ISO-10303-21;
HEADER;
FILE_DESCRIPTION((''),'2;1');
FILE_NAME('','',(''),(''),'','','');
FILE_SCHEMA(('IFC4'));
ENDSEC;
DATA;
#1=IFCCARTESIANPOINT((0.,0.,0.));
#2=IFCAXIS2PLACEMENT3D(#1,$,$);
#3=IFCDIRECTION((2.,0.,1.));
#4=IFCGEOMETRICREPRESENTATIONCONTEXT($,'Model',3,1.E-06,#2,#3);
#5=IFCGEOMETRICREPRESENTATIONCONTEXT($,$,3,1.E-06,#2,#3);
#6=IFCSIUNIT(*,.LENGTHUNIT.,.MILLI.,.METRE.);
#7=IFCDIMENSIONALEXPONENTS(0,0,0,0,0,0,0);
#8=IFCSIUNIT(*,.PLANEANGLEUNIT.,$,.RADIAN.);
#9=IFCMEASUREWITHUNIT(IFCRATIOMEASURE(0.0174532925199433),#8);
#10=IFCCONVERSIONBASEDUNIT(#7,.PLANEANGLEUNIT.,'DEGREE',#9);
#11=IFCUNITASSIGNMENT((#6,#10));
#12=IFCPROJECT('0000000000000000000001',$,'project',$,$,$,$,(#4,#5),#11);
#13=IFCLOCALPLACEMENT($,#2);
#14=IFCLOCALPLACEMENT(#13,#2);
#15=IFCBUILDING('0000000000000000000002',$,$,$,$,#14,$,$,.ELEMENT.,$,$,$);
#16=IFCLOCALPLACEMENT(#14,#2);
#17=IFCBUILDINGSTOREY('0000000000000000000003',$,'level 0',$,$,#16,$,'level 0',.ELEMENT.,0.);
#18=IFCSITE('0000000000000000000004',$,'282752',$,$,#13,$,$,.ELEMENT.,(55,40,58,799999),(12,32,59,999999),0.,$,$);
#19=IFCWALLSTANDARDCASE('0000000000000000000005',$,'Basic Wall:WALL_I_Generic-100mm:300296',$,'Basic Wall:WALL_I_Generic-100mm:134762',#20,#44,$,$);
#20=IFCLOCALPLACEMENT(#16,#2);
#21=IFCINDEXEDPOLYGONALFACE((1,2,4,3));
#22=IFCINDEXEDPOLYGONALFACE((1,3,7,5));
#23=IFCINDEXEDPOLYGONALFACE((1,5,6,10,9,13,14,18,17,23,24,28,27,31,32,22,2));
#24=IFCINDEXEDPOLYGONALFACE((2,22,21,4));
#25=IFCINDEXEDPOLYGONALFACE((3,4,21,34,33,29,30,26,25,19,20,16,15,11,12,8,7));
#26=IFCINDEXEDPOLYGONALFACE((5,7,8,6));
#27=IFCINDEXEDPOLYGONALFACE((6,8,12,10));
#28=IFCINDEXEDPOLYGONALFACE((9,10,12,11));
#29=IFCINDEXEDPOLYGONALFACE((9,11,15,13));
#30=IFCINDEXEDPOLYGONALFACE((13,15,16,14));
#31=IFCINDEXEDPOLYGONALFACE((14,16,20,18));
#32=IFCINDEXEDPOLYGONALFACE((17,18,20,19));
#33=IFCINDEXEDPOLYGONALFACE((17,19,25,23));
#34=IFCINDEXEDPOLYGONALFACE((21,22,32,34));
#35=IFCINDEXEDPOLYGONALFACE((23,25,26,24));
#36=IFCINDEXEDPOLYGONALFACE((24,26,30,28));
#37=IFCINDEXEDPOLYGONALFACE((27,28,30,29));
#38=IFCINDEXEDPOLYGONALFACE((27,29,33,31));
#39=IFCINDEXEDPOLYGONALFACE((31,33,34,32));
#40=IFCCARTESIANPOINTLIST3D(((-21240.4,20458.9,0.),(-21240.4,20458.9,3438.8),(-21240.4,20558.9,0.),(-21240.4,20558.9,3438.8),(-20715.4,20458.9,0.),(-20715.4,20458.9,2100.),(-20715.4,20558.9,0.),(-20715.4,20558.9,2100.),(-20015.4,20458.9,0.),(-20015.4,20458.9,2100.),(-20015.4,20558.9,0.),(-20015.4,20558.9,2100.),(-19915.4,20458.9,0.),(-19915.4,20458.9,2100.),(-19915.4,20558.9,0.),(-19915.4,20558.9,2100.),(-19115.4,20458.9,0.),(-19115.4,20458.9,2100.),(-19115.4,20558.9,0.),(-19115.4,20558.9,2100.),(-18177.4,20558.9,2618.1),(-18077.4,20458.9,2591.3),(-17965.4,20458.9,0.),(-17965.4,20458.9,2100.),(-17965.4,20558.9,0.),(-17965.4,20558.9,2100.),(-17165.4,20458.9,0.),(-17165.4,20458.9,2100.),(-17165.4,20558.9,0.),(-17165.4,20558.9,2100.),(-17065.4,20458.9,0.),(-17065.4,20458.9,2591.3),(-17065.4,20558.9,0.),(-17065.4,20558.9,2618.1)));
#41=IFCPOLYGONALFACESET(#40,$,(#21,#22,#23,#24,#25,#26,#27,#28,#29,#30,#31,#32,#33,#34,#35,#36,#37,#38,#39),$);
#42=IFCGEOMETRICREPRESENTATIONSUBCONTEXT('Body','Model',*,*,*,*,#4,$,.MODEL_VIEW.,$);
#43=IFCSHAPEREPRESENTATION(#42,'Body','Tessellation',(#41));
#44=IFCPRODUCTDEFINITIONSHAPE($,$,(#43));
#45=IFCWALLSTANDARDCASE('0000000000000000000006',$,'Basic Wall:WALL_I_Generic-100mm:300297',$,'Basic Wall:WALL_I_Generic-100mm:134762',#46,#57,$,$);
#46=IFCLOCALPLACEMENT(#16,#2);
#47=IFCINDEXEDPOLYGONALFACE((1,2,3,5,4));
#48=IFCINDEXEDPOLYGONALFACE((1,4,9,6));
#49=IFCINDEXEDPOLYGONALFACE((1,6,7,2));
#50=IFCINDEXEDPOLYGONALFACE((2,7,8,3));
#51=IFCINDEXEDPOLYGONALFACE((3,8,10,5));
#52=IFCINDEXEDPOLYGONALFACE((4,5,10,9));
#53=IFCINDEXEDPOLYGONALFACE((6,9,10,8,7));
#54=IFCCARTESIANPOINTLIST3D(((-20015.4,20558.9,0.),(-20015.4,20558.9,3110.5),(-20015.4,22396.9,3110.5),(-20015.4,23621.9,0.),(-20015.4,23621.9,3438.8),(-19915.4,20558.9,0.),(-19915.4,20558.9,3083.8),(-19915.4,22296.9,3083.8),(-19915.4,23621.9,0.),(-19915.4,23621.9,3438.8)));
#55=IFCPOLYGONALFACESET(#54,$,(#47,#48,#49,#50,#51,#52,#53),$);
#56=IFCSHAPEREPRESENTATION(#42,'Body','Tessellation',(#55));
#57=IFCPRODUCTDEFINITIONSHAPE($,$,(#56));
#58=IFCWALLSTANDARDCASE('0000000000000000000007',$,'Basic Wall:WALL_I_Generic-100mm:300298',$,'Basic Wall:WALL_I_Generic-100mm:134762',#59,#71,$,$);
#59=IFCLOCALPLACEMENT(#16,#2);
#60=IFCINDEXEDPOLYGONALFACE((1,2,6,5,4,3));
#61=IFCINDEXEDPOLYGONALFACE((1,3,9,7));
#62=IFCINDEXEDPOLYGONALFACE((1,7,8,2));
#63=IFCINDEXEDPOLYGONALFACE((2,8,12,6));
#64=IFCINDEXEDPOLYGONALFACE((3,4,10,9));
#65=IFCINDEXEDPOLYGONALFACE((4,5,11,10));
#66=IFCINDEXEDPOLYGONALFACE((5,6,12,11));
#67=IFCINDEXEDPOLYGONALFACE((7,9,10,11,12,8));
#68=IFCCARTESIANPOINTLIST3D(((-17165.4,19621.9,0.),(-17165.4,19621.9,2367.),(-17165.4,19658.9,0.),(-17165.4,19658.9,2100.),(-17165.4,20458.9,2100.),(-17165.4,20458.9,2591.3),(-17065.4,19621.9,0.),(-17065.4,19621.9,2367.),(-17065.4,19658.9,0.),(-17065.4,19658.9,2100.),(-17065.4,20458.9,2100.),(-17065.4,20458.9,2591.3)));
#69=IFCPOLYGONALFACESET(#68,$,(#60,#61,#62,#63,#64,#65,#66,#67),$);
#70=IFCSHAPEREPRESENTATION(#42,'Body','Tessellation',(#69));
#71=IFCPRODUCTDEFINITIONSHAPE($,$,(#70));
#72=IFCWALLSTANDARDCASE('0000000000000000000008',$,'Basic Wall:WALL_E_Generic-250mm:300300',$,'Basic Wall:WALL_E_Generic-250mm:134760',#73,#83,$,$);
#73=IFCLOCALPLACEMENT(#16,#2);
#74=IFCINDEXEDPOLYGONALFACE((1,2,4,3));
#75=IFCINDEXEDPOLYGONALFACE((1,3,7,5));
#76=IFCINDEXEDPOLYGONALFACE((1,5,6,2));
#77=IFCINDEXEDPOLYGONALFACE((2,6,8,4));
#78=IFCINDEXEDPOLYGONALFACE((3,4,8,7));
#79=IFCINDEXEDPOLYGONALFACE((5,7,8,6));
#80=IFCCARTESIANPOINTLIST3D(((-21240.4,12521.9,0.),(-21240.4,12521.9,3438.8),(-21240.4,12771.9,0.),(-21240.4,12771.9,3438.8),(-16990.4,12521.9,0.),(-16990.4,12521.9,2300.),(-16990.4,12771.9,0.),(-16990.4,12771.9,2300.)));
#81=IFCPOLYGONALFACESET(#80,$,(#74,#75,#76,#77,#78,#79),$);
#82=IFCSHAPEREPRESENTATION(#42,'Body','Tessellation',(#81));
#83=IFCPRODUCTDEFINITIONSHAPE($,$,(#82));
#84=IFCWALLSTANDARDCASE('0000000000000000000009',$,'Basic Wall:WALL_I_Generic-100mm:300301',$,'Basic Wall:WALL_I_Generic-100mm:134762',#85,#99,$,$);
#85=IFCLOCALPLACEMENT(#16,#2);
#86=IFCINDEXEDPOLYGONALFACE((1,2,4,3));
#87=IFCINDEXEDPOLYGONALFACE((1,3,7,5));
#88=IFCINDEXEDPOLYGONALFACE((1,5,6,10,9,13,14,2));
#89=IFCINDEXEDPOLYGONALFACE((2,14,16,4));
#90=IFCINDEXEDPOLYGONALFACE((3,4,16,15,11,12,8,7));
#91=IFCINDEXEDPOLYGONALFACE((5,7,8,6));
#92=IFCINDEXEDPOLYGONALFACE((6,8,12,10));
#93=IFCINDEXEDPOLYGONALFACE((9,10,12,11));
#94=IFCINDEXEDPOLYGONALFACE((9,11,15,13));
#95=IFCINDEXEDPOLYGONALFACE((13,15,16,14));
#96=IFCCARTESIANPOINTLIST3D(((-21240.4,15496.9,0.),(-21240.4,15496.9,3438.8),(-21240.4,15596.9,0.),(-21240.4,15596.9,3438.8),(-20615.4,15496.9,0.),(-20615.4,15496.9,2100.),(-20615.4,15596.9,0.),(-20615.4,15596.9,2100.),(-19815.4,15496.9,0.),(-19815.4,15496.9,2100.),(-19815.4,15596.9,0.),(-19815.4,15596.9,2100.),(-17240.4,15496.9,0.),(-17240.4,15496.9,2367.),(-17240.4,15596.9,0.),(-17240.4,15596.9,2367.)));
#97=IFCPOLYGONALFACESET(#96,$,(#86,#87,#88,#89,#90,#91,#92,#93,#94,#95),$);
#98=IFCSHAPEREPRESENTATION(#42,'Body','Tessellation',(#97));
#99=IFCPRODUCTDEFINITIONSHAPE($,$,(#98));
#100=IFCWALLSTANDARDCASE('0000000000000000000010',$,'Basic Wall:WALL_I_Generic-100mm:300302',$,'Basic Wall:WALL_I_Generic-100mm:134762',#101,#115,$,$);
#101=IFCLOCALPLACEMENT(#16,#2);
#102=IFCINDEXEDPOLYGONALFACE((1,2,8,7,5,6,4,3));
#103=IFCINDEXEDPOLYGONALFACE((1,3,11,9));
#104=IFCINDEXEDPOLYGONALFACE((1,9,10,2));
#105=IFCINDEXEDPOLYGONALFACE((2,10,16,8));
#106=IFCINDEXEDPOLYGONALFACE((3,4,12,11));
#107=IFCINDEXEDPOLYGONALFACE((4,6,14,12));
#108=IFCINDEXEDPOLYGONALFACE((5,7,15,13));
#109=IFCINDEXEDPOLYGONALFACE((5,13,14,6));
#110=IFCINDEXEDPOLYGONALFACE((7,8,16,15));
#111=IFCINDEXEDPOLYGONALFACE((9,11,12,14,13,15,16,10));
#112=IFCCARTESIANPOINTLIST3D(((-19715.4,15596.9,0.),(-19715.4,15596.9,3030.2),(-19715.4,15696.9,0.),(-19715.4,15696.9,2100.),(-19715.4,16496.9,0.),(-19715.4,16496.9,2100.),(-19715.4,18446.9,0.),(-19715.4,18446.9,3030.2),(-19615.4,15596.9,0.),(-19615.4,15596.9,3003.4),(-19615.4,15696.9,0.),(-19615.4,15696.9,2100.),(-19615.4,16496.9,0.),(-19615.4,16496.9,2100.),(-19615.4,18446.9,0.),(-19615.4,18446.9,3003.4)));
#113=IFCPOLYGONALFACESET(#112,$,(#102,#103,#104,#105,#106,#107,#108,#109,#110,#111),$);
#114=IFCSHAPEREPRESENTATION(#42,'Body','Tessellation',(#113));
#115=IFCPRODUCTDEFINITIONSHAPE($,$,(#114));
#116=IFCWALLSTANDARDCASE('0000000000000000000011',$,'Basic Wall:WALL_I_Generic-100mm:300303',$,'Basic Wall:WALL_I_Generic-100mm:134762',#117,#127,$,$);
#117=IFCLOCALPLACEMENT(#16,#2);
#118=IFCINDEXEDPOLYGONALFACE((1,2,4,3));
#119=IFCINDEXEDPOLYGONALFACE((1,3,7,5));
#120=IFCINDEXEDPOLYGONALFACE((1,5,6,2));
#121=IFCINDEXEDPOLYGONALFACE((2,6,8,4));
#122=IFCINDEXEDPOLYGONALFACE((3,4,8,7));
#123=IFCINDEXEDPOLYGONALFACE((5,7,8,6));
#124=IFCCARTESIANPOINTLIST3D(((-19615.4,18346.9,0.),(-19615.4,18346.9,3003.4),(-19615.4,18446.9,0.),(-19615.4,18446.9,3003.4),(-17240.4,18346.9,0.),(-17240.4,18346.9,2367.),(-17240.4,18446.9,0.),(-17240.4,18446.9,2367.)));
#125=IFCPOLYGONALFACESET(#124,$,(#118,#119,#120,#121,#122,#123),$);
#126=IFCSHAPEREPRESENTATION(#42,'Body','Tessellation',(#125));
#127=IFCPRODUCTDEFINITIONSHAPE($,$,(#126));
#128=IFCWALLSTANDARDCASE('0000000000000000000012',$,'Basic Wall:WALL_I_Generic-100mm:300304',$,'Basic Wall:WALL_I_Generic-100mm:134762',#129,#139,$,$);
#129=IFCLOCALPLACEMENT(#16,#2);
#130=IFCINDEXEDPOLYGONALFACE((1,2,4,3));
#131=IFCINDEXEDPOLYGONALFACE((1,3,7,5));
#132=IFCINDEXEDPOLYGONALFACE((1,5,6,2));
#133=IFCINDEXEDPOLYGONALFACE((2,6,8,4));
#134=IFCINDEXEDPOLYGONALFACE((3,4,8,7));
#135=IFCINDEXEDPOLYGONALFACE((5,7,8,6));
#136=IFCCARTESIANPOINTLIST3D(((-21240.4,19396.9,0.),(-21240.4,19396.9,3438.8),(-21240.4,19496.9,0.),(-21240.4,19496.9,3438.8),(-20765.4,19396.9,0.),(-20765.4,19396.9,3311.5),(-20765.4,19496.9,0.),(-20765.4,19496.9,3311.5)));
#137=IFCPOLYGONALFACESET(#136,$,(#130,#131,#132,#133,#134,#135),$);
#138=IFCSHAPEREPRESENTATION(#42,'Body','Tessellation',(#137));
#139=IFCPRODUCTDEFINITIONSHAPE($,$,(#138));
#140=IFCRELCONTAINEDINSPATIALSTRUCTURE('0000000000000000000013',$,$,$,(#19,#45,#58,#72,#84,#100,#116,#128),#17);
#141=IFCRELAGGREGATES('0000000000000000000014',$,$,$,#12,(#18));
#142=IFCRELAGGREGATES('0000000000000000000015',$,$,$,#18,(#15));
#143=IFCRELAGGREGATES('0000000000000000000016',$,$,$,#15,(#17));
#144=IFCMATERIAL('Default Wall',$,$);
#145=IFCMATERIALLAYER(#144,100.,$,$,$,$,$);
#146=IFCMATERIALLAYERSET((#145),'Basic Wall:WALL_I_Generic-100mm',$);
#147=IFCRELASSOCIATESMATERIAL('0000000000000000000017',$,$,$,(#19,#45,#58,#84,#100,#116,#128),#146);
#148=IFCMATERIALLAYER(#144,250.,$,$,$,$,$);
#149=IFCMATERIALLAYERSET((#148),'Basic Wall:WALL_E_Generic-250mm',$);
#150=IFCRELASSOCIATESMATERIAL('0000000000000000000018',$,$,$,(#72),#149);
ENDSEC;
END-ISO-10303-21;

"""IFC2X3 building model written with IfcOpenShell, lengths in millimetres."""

from ifc_helpers import new_model, entity, si_unit, converted_unit, direction, frame, frame_2d, origin, place, context, subcontext, project, spatial, polyline, rectangle, extrude, clip, bounded_halfspace, material, layer, layer_set, layer_usage, element, save


model = new_model("IFC2X3")

# Units and contexts
model_context = context("Model", 3, precision=1e-06, world=origin(), true_north=direction((2.0, 0.0, 1.0)))
context_of_model = context(None, 3, precision=1e-06, world=origin(), true_north=direction((2.0, 0.0, 1.0)))
body_context = subcontext(model_context, "Body", "Model", "MODEL_VIEW")
ifc_project = project(units=[si_unit("LENGTHUNIT", "METRE", prefix="MILLI"), converted_unit("PLANEANGLEUNIT", "DEGREE", entity("IfcRatioMeasure", 0.0174532925199433), si_unit("PLANEANGLEUNIT", "RADIAN"), dimensions=[0, 0, 0, 0, 0, 0, 0])], contexts=[model_context, context_of_model])

# Site, building, storey
site_placement = place(None, origin())
site = spatial("IfcSite", under=ifc_project, at=site_placement, Name="282752", CompositionType="ELEMENT", RefLatitude=(55, 40, 58, 799999), RefLongitude=(12, 32, 59, 999999), RefElevation=0.0)
building_placement = place(site_placement, origin())
building = spatial("IfcBuilding", under=site, at=building_placement, CompositionType="ELEMENT")
storey_placement = place(building_placement, origin())
storey = spatial("IfcBuildingStorey", under=building, at=storey_placement, Name="level 0", LongName="level 0", CompositionType="ELEMENT", Elevation=0.0)

# Wall, openings
ifc_material_1 = material(Name="Default Wall")
ifc_layer_1 = layer(ifc_material_1, 100.0)
ifc_layer_set_1 = layer_set([ifc_layer_1], Name="Basic Wall:WALL_I_Generic-100mm")
ifc_layer_usage_1 = layer_usage(ifc_layer_set_1, "AXIS2", "NEGATIVE", 50.0)
wall_1_placement = place(storey_placement, frame((-21240.4, 20508.9, 0.0)))
wall_1 = element("IfcWallStandardCase", 1, at=wall_1_placement, inside=storey, material=ifc_layer_usage_1, Name="Basic Wall:WALL_I_Generic-100mm:300296", ObjectType="Basic Wall:WALL_I_Generic-100mm:134762", context=body_context, shape_type="Clipping", body=[
    clip(clip(extrude(rectangle(XDim=4175.0, YDim=100.0, at=frame_2d((2087.5, 0.0), x_axis=(-1.0, 0.0))), origin(), (0.0, 0.0, 1.0), 4213.2), bounded_halfspace(frame((0.0, 50.0, 3438.8), z_axis=(0.258819, 0.0, 0.965926), x_axis=(0.0, 1.0, 0.0)), False, frame((0.0, 50.0, 3438.8)), polyline([(0.0, 0.0), (0.0, -100.0), (3163.0, -100.0), (3063.0, 0.0), (2675.0, 0.0), (2575.0, 0.0), (1325.0, 0.0), (1225.0, 0.0), (0.0, 0.0)]))), bounded_halfspace(frame((3163.0, -50.0, 2591.3), z_axis=(0.0, -0.258819, 0.965926), x_axis=(1.0, 0.0, 0.0)), False, frame((3163.0, -50.0, 2591.3)), polyline([(0.0, 0.0), (912.0, 0.0), (1012.0, 0.0), (1012.0, 100.0), (-100.0, 100.0), (0.0, 0.0)]))),
])
opening_1_placement = place(wall_1_placement, frame((1325.0, -50.0, 0.0)))
element("IfcOpeningElement", 2, at=opening_1_placement, cuts=wall_1, ObjectType="Opening", context=body_context, shape_type="SweptSolid", body=[
    extrude(rectangle(XDim=2100.0, YDim=800.0, at=frame_2d((1050.0, 400.0), x_axis=(1.0, 0.0))), frame((0.0, 0.0, 0.0), z_axis=(0.0, 1.0, 0.0), x_axis=(0.0, 0.0, 1.0)), (0.0, 0.0, 1.0), 100.0),
])
opening_2_placement = place(wall_1_placement, frame((525.0, -50.0, 0.0)))
element("IfcOpeningElement", 3, at=opening_2_placement, cuts=wall_1, ObjectType="Opening", context=body_context, shape_type="SweptSolid", body=[
    extrude(rectangle(XDim=2100.0, YDim=700.0, at=frame_2d((1050.0, 350.0), x_axis=(1.0, 0.0))), frame((0.0, 0.0, 0.0), z_axis=(0.0, 1.0, 0.0), x_axis=(0.0, 0.0, 1.0)), (0.0, 0.0, 1.0), 100.0),
])
opening_3_placement = place(wall_1_placement, frame((3275.0, -50.0, 0.0)))
element("IfcOpeningElement", 4, at=opening_3_placement, cuts=wall_1, ObjectType="Opening", context=body_context, shape_type="SweptSolid", body=[
    extrude(rectangle(XDim=2100.0, YDim=800.0, at=frame_2d((1050.0, 400.0), x_axis=(1.0, 0.0))), frame((0.0, 0.0, 0.0), z_axis=(0.0, 1.0, 0.0), x_axis=(0.0, 0.0, 1.0)), (0.0, 0.0, 1.0), 100.0),
])

# Wall
ifc_layer_usage_2 = layer_usage(ifc_layer_set_1, "AXIS2", "NEGATIVE", 50.0)
wall_2_placement = place(storey_placement, frame((-19965.4, 20558.9, 0.0), z_axis=(0.0, 0.0, 1.0), x_axis=(0.0, 1.0, 0.0)))
element("IfcWallStandardCase", 5, at=wall_2_placement, inside=storey, material=ifc_layer_usage_2, Name="Basic Wall:WALL_I_Generic-100mm:300297", ObjectType="Basic Wall:WALL_I_Generic-100mm:134762", context=body_context, shape_type="Clipping", body=[
    clip(clip(extrude(rectangle(XDim=3063.0, YDim=100.0, at=frame_2d((1531.5, 0.0), x_axis=(-1.0, 0.0))), origin(), (0.0, 0.0, 1.0), 4213.2), bounded_halfspace(frame((0.0, -50.0, 3083.8), z_axis=(0.0, -0.258819, 0.965926), x_axis=(1.0, 0.0, 0.0)), False, frame((0.0, -50.0, 3083.8)), polyline([(0.0, 0.0), (1738.0, 0.0), (1838.0, 100.0), (0.0, 100.0), (0.0, 0.0)]))), bounded_halfspace(frame((1738.0, -50.0, 3083.8), z_axis=(-0.258819, 0.0, 0.965926), x_axis=(0.0, -1.0, 0.0)), False, frame((1738.0, -50.0, 3083.8)), polyline([(0.0, 0.0), (1325.0, 0.0), (1325.0, 100.0), (100.0, 100.0), (0.0, 0.0)]))),
])

# Wall, opening
ifc_layer_usage_3 = layer_usage(ifc_layer_set_1, "AXIS2", "NEGATIVE", 50.0)
wall_3_placement = place(storey_placement, frame((-17115.4, 20458.9, 0.0), z_axis=(0.0, 0.0, 1.0), x_axis=(0.0, -1.0, 0.0)))
wall_3 = element("IfcWallStandardCase", 6, at=wall_3_placement, inside=storey, material=ifc_layer_usage_3, Name="Basic Wall:WALL_I_Generic-100mm:300298", ObjectType="Basic Wall:WALL_I_Generic-100mm:134762", context=body_context, shape_type="Clipping", body=[
    clip(extrude(rectangle(XDim=837.0, YDim=100.0, at=frame_2d((418.5, 0.0), x_axis=(-1.0, 0.0))), origin(), (0.0, 0.0, 1.0), 2593.3), bounded_halfspace(frame((0.0, -50.0, 2591.3), z_axis=(0.258819, 0.0, 0.965926), x_axis=(0.0, 1.0, 0.0)), False, frame((0.0, -50.0, 2591.3)), polyline([(0.0, 0.0), (837.0, 0.0), (837.0, 100.0), (0.0, 100.0), (0.0, 0.0)]))),
])
opening_4_placement = place(wall_3_placement, frame((0.0, -50.0, 0.0)))
element("IfcOpeningElement", 7, at=opening_4_placement, cuts=wall_3, ObjectType="Opening", context=body_context, shape_type="SweptSolid", body=[
    extrude(rectangle(XDim=2100.0, YDim=800.0, at=frame_2d((1050.0, 400.0), x_axis=(1.0, 0.0))), frame((0.0, 0.0, 0.0), z_axis=(0.0, 1.0, 0.0), x_axis=(0.0, 0.0, 1.0)), (0.0, 0.0, 1.0), 100.0),
])

# Wall
ifc_layer_2 = layer(ifc_material_1, 250.0)
ifc_layer_set_2 = layer_set([ifc_layer_2], Name="Basic Wall:WALL_E_Generic-250mm")
ifc_layer_usage_4 = layer_usage(ifc_layer_set_2, "AXIS2", "NEGATIVE", 125.0)
wall_4_placement = place(storey_placement, frame((-16990.4, 12646.9, 0.0), z_axis=(0.0, 0.0, 1.0), x_axis=(-1.0, 0.0, 0.0)))
element("IfcWallStandardCase", 8, at=wall_4_placement, inside=storey, material=ifc_layer_usage_4, Name="Basic Wall:WALL_E_Generic-250mm:300300", ObjectType="Basic Wall:WALL_E_Generic-250mm:134760", context=body_context, shape_type="Clipping", body=[
    clip(extrude(rectangle(XDim=4250.0, YDim=250.0, at=frame_2d((2125.0, 0.0), x_axis=(-1.0, 0.0))), origin(), (0.0, 0.0, 1.0), 3438.8), bounded_halfspace(frame((0.0, -125.0, 2300.0), z_axis=(-0.258819, 0.0, 0.965926), x_axis=(0.0, -1.0, 0.0)), False, frame((0.0, -125.0, 2300.0)), polyline([(0.0, 0.0), (250.0, 0.0), (4250.0, 0.0), (4250.0, 250.0), (0.0, 250.0), (0.0, 0.0)]))),
])

# Walls, openings
ifc_layer_usage_5 = layer_usage(ifc_layer_set_1, "AXIS2", "NEGATIVE", 50.0)
wall_5_placement = place(storey_placement, frame((-21240.4, 15546.9, 0.0)))
wall_5 = element("IfcWallStandardCase", 9, at=wall_5_placement, inside=storey, material=ifc_layer_usage_5, Name="Basic Wall:WALL_I_Generic-100mm:300301", ObjectType="Basic Wall:WALL_I_Generic-100mm:134762", context=body_context, shape_type="Clipping", body=[
    clip(extrude(rectangle(XDim=4000.0, YDim=100.0, at=frame_2d((2000.0, 0.0), x_axis=(-1.0, 0.0))), origin(), (0.0, 0.0, 1.0), 3438.8), bounded_halfspace(frame((0.0, -50.0, 3438.8), z_axis=(0.258819, 0.0, 0.965926), x_axis=(0.0, 1.0, 0.0)), False, frame((0.0, -50.0, 3438.8)), polyline([(0.0, 0.0), (4000.0, 0.0), (4000.0, 100.0), (1625.0, 100.0), (1525.0, 100.0), (0.0, 100.0), (0.0, 0.0)]))),
])
opening_5_placement = place(wall_5_placement, frame((1425.0, 50.0, 0.0)))
element("IfcOpeningElement", 10, at=opening_5_placement, cuts=wall_5, ObjectType="Opening", context=body_context, shape_type="SweptSolid", body=[
    extrude(rectangle(XDim=2100.0, YDim=800.0, at=frame_2d((1050.0, 400.0), x_axis=(1.0, 0.0))), frame((0.0, 0.0, 0.0), z_axis=(0.0, -1.0, 0.0), x_axis=(0.0, 0.0, 1.0)), (0.0, 0.0, 1.0), 100.0),
])
ifc_layer_usage_6 = layer_usage(ifc_layer_set_1, "AXIS2", "NEGATIVE", 50.0)
wall_6_placement = place(storey_placement, frame((-19665.4, 15596.9, 0.0), z_axis=(0.0, 0.0, 1.0), x_axis=(0.0, 1.0, 0.0)))
wall_6 = element("IfcWallStandardCase", 11, at=wall_6_placement, inside=storey, material=ifc_layer_usage_6, Name="Basic Wall:WALL_I_Generic-100mm:300302", ObjectType="Basic Wall:WALL_I_Generic-100mm:134762", context=body_context, shape_type="Clipping", body=[
    clip(extrude(rectangle(XDim=2850.0, YDim=100.0, at=frame_2d((1425.0, 0.0), x_axis=(-1.0, 0.0))), origin(), (0.0, 0.0, 1.0), 3030.2), bounded_halfspace(frame((0.0, -50.0, 3003.4), z_axis=(0.0, -0.258819, 0.965926), x_axis=(1.0, 0.0, 0.0)), False, frame((0.0, -50.0, 3003.4)), polyline([(0.0, 0.0), (2750.0, 0.0), (2850.0, 0.0), (2850.0, 100.0), (0.0, 100.0), (0.0, 0.0)]))),
])
opening_6_placement = place(wall_6_placement, frame((900.0, 50.0, 0.0)))
element("IfcOpeningElement", 12, at=opening_6_placement, cuts=wall_6, ObjectType="Opening", context=body_context, shape_type="SweptSolid", body=[
    extrude(rectangle(XDim=2100.0, YDim=800.0, at=frame_2d((1050.0, 400.0), x_axis=(1.0, 0.0))), frame((0.0, 0.0, 0.0), z_axis=(0.0, -1.0, 0.0), x_axis=(0.0, 0.0, 1.0)), (0.0, 0.0, 1.0), 100.0),
])

# Walls
ifc_layer_usage_7 = layer_usage(ifc_layer_set_1, "AXIS2", "NEGATIVE", 50.0)
wall_7_placement = place(storey_placement, frame((-19615.4, 18396.9, 0.0)))
element("IfcWallStandardCase", 13, at=wall_7_placement, inside=storey, material=ifc_layer_usage_7, Name="Basic Wall:WALL_I_Generic-100mm:300303", ObjectType="Basic Wall:WALL_I_Generic-100mm:134762", context=body_context, shape_type="Clipping", body=[
    clip(extrude(rectangle(XDim=2375.0, YDim=100.0, at=frame_2d((1187.5, 0.0), x_axis=(-1.0, 0.0))), origin(), (0.0, 0.0, 1.0), 3003.4), bounded_halfspace(frame((0.0, -50.0, 3003.4), z_axis=(0.258819, 0.0, 0.965926), x_axis=(0.0, 1.0, 0.0)), False, frame((0.0, -50.0, 3003.4)), polyline([(0.0, 0.0), (2375.0, 0.0), (2375.0, 100.0), (0.0, 100.0), (0.0, 0.0)]))),
])
ifc_layer_usage_8 = layer_usage(ifc_layer_set_1, "AXIS2", "NEGATIVE", 50.0)
wall_8_placement = place(storey_placement, frame((-21240.4, 19446.9, 0.0)))
element("IfcWallStandardCase", 14, at=wall_8_placement, inside=storey, material=ifc_layer_usage_8, Name="Basic Wall:WALL_I_Generic-100mm:300304", ObjectType="Basic Wall:WALL_I_Generic-100mm:134762", context=body_context, shape_type="Clipping", body=[
    clip(extrude(rectangle(XDim=475.0, YDim=100.0, at=frame_2d((237.5, 0.0), x_axis=(-1.0, 0.0))), origin(), (0.0, 0.0, 1.0), 3438.8), bounded_halfspace(frame((0.0, -50.0, 3438.8), z_axis=(0.258819, 0.0, 0.965926), x_axis=(0.0, 1.0, 0.0)), False, frame((0.0, -50.0, 3438.8)), polyline([(0.0, 0.0), (475.0, 0.0), (475.0, 100.0), (0.0, 100.0), (0.0, 0.0)]))),
])

save(model, "model.ifc")
